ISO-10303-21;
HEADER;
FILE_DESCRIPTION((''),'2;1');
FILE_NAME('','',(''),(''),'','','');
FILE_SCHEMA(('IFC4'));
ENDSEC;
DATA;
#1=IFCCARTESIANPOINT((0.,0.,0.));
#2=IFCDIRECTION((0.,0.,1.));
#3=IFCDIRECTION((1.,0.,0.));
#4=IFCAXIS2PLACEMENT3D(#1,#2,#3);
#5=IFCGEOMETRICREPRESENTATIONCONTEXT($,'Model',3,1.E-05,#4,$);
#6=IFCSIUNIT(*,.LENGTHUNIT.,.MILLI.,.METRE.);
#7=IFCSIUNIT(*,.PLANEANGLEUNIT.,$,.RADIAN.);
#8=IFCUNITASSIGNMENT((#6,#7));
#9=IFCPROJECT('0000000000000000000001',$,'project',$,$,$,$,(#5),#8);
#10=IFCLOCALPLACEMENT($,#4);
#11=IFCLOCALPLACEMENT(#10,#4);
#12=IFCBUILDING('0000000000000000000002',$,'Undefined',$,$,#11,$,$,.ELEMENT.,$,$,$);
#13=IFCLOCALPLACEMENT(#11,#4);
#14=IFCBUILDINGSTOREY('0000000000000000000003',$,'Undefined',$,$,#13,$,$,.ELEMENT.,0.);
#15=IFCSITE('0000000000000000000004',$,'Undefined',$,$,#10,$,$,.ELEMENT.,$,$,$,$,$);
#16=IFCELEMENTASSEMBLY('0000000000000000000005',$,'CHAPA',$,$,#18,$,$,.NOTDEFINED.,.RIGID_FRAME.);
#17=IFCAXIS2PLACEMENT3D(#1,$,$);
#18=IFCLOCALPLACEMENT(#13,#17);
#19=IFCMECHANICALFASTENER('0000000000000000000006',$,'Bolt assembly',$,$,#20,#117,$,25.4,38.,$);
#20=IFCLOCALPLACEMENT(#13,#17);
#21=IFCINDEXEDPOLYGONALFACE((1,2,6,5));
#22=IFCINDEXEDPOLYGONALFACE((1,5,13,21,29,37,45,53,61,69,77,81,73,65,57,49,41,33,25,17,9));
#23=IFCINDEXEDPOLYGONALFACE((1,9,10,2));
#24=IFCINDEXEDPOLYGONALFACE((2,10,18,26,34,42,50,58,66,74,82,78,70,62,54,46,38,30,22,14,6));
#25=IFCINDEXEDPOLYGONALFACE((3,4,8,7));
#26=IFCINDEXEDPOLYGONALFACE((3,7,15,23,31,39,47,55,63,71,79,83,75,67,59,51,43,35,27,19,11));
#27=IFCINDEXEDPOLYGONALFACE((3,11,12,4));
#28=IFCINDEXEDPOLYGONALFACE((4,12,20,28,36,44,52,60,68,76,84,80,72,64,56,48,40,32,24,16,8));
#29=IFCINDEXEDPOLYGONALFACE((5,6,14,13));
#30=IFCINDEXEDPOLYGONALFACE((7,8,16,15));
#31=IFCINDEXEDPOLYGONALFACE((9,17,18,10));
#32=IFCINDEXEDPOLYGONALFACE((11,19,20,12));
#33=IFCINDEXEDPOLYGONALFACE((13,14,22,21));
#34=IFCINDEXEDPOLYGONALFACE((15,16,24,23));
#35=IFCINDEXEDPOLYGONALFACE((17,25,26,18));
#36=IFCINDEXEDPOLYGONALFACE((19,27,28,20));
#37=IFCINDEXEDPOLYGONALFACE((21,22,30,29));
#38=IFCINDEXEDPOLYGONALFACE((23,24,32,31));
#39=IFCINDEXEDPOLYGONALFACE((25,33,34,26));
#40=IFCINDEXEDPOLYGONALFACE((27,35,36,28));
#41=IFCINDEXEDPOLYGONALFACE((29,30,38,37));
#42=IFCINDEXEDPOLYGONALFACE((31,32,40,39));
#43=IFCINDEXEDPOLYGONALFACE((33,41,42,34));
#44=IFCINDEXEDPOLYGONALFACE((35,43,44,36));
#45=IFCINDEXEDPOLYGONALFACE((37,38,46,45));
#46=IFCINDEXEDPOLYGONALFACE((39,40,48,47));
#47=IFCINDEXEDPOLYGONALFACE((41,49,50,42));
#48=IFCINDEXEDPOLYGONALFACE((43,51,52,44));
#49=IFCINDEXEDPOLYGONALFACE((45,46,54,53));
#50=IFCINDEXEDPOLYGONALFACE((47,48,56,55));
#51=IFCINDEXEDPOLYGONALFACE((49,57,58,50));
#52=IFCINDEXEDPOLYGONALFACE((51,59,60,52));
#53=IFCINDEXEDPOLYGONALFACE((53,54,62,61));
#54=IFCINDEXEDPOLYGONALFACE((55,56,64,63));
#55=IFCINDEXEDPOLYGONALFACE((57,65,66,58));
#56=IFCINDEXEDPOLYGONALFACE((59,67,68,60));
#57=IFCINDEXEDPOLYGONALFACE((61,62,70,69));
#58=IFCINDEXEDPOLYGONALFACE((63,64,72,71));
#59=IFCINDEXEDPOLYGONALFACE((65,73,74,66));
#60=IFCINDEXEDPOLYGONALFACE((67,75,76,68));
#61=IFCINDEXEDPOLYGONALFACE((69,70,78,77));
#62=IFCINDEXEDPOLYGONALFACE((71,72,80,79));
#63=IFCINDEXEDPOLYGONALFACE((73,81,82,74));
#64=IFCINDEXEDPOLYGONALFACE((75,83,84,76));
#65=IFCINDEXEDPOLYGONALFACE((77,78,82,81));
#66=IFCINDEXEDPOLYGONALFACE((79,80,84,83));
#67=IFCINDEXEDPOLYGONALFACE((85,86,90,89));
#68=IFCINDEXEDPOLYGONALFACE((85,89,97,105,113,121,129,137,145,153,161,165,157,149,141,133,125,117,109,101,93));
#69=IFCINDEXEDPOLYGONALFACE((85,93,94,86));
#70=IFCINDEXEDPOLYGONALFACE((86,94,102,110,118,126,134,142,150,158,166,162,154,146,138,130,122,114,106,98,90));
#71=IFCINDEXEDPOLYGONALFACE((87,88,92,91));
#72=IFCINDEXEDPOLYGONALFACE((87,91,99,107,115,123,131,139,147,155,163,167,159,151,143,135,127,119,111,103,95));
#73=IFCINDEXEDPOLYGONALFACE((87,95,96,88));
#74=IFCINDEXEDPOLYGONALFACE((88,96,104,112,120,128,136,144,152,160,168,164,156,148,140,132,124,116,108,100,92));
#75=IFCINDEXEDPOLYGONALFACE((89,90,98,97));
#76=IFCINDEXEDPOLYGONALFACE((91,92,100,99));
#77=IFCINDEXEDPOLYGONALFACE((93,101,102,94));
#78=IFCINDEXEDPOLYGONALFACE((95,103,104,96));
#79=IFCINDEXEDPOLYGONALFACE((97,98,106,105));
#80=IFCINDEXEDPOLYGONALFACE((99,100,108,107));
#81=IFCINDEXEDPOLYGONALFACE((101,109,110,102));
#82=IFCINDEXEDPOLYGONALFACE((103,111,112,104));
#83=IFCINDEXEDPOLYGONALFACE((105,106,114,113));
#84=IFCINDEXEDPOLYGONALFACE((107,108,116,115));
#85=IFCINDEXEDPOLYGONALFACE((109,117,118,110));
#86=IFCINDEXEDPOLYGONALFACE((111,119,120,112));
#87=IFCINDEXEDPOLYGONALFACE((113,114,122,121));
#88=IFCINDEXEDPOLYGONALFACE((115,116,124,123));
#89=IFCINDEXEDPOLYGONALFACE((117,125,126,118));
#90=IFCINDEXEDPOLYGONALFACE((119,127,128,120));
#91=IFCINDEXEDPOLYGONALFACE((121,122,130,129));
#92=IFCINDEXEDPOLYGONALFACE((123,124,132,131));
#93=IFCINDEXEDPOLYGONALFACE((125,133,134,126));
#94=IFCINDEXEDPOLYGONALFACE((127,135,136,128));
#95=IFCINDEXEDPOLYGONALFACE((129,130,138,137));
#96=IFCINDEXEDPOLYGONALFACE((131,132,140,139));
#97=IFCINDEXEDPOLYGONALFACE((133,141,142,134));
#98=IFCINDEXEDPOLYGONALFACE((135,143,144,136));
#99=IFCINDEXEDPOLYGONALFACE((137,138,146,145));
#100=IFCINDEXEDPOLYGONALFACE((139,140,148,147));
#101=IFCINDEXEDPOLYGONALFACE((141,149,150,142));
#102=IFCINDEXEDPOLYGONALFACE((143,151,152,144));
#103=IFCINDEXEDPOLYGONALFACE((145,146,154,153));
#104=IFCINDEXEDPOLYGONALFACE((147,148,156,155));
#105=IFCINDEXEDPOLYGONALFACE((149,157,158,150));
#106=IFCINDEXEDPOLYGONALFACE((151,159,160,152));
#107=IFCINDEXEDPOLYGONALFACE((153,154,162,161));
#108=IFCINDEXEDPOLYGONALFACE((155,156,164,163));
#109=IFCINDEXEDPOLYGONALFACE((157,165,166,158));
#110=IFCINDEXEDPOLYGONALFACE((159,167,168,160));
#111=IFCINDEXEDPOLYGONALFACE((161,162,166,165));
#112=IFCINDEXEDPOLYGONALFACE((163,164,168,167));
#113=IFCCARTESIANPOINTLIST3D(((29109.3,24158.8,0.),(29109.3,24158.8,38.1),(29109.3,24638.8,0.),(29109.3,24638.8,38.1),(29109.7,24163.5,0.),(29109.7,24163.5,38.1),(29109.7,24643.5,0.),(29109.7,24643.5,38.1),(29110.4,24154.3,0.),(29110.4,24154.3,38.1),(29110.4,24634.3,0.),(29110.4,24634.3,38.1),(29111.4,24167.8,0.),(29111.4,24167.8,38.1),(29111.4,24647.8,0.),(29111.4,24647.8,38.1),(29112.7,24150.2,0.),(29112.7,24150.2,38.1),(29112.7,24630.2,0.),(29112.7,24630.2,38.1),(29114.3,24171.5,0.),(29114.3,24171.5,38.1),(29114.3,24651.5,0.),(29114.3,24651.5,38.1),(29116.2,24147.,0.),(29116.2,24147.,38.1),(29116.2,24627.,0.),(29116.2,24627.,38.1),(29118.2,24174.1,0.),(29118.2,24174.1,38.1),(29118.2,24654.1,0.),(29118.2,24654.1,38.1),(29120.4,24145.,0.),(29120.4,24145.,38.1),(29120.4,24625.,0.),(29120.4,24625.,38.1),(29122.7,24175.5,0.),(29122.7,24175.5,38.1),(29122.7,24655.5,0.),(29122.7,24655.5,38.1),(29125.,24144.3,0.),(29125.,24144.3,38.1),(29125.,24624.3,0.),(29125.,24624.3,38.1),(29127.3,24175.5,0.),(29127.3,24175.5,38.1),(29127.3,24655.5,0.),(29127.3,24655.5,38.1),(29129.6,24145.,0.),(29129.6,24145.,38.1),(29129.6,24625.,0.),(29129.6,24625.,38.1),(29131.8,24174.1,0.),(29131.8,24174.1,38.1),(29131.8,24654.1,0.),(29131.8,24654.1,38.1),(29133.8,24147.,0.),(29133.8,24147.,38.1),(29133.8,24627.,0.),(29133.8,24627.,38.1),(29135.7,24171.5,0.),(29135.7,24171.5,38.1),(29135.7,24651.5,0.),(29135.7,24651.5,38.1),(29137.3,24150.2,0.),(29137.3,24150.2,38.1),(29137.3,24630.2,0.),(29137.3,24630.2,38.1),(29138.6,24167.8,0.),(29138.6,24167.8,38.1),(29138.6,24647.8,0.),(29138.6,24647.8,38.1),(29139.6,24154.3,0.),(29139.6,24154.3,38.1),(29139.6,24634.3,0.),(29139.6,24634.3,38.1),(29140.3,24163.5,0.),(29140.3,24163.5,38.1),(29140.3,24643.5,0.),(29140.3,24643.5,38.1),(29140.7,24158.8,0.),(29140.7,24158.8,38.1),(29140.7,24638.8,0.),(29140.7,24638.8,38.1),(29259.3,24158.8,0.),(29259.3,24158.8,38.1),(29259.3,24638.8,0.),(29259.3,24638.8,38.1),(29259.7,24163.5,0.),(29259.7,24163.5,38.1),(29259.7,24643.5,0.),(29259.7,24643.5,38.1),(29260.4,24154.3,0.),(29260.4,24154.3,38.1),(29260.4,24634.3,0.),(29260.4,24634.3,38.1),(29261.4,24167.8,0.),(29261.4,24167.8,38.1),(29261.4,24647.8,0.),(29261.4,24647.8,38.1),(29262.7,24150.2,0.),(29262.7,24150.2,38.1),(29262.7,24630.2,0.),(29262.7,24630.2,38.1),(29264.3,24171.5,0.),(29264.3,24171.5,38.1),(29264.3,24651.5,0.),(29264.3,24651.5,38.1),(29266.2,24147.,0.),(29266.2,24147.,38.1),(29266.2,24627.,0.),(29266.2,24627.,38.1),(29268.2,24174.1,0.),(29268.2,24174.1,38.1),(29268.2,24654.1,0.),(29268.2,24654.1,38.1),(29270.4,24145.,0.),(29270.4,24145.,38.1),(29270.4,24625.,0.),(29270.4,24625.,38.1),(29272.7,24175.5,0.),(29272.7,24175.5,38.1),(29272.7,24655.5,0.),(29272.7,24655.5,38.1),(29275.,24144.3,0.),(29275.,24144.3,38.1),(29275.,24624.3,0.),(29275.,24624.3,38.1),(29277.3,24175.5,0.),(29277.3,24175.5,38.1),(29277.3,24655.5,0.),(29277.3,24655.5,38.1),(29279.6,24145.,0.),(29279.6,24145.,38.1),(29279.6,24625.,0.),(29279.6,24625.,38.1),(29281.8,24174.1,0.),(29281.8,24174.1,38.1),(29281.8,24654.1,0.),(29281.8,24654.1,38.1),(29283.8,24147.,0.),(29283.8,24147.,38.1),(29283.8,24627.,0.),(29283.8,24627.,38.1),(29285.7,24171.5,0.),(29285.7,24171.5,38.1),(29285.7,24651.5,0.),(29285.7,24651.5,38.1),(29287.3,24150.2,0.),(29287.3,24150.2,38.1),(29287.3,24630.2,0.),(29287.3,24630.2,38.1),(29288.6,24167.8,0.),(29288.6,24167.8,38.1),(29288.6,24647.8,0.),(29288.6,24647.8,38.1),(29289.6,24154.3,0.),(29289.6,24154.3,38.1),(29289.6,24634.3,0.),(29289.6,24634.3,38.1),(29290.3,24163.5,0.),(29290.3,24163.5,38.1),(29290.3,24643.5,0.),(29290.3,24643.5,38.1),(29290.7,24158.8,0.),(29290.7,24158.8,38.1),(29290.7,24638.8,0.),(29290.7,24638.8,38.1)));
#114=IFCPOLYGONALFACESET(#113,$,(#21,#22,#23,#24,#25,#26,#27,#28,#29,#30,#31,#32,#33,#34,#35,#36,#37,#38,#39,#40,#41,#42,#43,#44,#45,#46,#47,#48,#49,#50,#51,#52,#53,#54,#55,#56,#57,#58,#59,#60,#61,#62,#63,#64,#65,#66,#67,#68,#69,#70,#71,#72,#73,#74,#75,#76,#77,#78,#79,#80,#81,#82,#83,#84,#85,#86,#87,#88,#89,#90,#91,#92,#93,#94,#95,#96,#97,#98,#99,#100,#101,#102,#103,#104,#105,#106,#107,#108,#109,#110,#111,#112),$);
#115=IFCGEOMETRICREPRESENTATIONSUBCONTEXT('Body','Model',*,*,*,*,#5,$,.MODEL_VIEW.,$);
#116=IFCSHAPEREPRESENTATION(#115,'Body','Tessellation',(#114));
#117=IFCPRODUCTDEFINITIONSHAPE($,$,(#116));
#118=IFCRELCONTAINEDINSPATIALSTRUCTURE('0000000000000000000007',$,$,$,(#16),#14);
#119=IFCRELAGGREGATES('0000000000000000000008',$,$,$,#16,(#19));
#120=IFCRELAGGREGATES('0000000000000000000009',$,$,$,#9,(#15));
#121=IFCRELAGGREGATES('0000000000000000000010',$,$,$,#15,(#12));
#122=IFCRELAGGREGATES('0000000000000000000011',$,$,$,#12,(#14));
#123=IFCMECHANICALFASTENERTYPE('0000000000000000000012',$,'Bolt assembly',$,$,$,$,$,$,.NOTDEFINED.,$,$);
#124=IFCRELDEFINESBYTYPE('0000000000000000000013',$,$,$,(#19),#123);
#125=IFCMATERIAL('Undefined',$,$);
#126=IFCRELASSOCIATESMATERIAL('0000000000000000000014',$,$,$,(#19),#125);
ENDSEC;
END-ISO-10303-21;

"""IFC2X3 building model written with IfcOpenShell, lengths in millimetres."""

from ifc_helpers import new_model, si_unit, frame, origin_with_axes, origin_2d_with_axis, place, context, subcontext, project, spatial, circle, extrude, source, transform, mapped, material, type_object, element, aggregate, save


model = new_model("IFC2X3")

# Units and contexts
model_context = context("Model", 3, precision=1e-05, world=origin_with_axes())
body_context = subcontext(model_context, "Body", "Model", "MODEL_VIEW")
ifc_project = project(units=[si_unit("LENGTHUNIT", "METRE", prefix="MILLI"), si_unit("PLANEANGLEUNIT", "RADIAN")], contexts=[model_context])

# Site, building, storey
site_placement = place(None, origin_with_axes())
site = spatial("IfcSite", under=ifc_project, at=site_placement, Name="Undefined", CompositionType="ELEMENT")
building_placement = place(site_placement, origin_with_axes())
building = spatial("IfcBuilding", under=site, at=building_placement, Name="Undefined", CompositionType="ELEMENT")
storey_placement = place(building_placement, origin_with_axes())
storey = spatial("IfcBuildingStorey", under=building, at=storey_placement, Name="Undefined", CompositionType="ELEMENT", Elevation=0.0)

# Element assembly
assembly_1_placement = place(storey_placement, origin_with_axes())
assembly_1 = element("IfcElementAssembly", 1, at=assembly_1_placement, inside=storey, Name="CHAPA", AssemblyPlace="NOTDEFINED", PredefinedType="RIGID_FRAME")

# Shared definitions
ifc_material_1 = material(Name="Undefined")
mechanical_fastener_type = type_object("IfcMechanicalFastenerType", Name="Bolt assembly")

# Mechanical fastener
shared_shape_1 = source(origin_with_axes(), body_context, "Body", "SweptSolid", [
    extrude(circle(Radius=15.7, at=origin_2d_with_axis()), frame((0.0, -38.0, 0.0), z_axis=(0.0, 1.0, 0.0), x_axis=(1.0, 0.0, 0.0)), (0.0, 0.0, 1.0), 38.1),
])
mechanical_fastener_1_placement = place(assembly_1_placement, frame((29200.0, 24640.0, 38.0), z_axis=(-1.0, 0.0, 0.0), x_axis=(0.0, -1.0, 0.0)))
mechanical_fastener_1 = element("IfcMechanicalFastener", 2, at=mechanical_fastener_1_placement, type_object=mechanical_fastener_type, material=ifc_material_1, Name="Bolt assembly", NominalDiameter=25.4, NominalLength=38.0, context=body_context, shape_type="MappedRepresentation", body=[
    mapped(shared_shape_1, transform((0.0, 0.0, -75.0))),
    mapped(shared_shape_1, transform((0.0, 0.0, 75.0))),
    mapped(shared_shape_1, transform((480.0, 0.0, -75.0))),
    mapped(shared_shape_1, transform((480.0, 0.0, 75.0))),
])
aggregate(assembly_1, [mechanical_fastener_1])

save(model, "model.ifc")
